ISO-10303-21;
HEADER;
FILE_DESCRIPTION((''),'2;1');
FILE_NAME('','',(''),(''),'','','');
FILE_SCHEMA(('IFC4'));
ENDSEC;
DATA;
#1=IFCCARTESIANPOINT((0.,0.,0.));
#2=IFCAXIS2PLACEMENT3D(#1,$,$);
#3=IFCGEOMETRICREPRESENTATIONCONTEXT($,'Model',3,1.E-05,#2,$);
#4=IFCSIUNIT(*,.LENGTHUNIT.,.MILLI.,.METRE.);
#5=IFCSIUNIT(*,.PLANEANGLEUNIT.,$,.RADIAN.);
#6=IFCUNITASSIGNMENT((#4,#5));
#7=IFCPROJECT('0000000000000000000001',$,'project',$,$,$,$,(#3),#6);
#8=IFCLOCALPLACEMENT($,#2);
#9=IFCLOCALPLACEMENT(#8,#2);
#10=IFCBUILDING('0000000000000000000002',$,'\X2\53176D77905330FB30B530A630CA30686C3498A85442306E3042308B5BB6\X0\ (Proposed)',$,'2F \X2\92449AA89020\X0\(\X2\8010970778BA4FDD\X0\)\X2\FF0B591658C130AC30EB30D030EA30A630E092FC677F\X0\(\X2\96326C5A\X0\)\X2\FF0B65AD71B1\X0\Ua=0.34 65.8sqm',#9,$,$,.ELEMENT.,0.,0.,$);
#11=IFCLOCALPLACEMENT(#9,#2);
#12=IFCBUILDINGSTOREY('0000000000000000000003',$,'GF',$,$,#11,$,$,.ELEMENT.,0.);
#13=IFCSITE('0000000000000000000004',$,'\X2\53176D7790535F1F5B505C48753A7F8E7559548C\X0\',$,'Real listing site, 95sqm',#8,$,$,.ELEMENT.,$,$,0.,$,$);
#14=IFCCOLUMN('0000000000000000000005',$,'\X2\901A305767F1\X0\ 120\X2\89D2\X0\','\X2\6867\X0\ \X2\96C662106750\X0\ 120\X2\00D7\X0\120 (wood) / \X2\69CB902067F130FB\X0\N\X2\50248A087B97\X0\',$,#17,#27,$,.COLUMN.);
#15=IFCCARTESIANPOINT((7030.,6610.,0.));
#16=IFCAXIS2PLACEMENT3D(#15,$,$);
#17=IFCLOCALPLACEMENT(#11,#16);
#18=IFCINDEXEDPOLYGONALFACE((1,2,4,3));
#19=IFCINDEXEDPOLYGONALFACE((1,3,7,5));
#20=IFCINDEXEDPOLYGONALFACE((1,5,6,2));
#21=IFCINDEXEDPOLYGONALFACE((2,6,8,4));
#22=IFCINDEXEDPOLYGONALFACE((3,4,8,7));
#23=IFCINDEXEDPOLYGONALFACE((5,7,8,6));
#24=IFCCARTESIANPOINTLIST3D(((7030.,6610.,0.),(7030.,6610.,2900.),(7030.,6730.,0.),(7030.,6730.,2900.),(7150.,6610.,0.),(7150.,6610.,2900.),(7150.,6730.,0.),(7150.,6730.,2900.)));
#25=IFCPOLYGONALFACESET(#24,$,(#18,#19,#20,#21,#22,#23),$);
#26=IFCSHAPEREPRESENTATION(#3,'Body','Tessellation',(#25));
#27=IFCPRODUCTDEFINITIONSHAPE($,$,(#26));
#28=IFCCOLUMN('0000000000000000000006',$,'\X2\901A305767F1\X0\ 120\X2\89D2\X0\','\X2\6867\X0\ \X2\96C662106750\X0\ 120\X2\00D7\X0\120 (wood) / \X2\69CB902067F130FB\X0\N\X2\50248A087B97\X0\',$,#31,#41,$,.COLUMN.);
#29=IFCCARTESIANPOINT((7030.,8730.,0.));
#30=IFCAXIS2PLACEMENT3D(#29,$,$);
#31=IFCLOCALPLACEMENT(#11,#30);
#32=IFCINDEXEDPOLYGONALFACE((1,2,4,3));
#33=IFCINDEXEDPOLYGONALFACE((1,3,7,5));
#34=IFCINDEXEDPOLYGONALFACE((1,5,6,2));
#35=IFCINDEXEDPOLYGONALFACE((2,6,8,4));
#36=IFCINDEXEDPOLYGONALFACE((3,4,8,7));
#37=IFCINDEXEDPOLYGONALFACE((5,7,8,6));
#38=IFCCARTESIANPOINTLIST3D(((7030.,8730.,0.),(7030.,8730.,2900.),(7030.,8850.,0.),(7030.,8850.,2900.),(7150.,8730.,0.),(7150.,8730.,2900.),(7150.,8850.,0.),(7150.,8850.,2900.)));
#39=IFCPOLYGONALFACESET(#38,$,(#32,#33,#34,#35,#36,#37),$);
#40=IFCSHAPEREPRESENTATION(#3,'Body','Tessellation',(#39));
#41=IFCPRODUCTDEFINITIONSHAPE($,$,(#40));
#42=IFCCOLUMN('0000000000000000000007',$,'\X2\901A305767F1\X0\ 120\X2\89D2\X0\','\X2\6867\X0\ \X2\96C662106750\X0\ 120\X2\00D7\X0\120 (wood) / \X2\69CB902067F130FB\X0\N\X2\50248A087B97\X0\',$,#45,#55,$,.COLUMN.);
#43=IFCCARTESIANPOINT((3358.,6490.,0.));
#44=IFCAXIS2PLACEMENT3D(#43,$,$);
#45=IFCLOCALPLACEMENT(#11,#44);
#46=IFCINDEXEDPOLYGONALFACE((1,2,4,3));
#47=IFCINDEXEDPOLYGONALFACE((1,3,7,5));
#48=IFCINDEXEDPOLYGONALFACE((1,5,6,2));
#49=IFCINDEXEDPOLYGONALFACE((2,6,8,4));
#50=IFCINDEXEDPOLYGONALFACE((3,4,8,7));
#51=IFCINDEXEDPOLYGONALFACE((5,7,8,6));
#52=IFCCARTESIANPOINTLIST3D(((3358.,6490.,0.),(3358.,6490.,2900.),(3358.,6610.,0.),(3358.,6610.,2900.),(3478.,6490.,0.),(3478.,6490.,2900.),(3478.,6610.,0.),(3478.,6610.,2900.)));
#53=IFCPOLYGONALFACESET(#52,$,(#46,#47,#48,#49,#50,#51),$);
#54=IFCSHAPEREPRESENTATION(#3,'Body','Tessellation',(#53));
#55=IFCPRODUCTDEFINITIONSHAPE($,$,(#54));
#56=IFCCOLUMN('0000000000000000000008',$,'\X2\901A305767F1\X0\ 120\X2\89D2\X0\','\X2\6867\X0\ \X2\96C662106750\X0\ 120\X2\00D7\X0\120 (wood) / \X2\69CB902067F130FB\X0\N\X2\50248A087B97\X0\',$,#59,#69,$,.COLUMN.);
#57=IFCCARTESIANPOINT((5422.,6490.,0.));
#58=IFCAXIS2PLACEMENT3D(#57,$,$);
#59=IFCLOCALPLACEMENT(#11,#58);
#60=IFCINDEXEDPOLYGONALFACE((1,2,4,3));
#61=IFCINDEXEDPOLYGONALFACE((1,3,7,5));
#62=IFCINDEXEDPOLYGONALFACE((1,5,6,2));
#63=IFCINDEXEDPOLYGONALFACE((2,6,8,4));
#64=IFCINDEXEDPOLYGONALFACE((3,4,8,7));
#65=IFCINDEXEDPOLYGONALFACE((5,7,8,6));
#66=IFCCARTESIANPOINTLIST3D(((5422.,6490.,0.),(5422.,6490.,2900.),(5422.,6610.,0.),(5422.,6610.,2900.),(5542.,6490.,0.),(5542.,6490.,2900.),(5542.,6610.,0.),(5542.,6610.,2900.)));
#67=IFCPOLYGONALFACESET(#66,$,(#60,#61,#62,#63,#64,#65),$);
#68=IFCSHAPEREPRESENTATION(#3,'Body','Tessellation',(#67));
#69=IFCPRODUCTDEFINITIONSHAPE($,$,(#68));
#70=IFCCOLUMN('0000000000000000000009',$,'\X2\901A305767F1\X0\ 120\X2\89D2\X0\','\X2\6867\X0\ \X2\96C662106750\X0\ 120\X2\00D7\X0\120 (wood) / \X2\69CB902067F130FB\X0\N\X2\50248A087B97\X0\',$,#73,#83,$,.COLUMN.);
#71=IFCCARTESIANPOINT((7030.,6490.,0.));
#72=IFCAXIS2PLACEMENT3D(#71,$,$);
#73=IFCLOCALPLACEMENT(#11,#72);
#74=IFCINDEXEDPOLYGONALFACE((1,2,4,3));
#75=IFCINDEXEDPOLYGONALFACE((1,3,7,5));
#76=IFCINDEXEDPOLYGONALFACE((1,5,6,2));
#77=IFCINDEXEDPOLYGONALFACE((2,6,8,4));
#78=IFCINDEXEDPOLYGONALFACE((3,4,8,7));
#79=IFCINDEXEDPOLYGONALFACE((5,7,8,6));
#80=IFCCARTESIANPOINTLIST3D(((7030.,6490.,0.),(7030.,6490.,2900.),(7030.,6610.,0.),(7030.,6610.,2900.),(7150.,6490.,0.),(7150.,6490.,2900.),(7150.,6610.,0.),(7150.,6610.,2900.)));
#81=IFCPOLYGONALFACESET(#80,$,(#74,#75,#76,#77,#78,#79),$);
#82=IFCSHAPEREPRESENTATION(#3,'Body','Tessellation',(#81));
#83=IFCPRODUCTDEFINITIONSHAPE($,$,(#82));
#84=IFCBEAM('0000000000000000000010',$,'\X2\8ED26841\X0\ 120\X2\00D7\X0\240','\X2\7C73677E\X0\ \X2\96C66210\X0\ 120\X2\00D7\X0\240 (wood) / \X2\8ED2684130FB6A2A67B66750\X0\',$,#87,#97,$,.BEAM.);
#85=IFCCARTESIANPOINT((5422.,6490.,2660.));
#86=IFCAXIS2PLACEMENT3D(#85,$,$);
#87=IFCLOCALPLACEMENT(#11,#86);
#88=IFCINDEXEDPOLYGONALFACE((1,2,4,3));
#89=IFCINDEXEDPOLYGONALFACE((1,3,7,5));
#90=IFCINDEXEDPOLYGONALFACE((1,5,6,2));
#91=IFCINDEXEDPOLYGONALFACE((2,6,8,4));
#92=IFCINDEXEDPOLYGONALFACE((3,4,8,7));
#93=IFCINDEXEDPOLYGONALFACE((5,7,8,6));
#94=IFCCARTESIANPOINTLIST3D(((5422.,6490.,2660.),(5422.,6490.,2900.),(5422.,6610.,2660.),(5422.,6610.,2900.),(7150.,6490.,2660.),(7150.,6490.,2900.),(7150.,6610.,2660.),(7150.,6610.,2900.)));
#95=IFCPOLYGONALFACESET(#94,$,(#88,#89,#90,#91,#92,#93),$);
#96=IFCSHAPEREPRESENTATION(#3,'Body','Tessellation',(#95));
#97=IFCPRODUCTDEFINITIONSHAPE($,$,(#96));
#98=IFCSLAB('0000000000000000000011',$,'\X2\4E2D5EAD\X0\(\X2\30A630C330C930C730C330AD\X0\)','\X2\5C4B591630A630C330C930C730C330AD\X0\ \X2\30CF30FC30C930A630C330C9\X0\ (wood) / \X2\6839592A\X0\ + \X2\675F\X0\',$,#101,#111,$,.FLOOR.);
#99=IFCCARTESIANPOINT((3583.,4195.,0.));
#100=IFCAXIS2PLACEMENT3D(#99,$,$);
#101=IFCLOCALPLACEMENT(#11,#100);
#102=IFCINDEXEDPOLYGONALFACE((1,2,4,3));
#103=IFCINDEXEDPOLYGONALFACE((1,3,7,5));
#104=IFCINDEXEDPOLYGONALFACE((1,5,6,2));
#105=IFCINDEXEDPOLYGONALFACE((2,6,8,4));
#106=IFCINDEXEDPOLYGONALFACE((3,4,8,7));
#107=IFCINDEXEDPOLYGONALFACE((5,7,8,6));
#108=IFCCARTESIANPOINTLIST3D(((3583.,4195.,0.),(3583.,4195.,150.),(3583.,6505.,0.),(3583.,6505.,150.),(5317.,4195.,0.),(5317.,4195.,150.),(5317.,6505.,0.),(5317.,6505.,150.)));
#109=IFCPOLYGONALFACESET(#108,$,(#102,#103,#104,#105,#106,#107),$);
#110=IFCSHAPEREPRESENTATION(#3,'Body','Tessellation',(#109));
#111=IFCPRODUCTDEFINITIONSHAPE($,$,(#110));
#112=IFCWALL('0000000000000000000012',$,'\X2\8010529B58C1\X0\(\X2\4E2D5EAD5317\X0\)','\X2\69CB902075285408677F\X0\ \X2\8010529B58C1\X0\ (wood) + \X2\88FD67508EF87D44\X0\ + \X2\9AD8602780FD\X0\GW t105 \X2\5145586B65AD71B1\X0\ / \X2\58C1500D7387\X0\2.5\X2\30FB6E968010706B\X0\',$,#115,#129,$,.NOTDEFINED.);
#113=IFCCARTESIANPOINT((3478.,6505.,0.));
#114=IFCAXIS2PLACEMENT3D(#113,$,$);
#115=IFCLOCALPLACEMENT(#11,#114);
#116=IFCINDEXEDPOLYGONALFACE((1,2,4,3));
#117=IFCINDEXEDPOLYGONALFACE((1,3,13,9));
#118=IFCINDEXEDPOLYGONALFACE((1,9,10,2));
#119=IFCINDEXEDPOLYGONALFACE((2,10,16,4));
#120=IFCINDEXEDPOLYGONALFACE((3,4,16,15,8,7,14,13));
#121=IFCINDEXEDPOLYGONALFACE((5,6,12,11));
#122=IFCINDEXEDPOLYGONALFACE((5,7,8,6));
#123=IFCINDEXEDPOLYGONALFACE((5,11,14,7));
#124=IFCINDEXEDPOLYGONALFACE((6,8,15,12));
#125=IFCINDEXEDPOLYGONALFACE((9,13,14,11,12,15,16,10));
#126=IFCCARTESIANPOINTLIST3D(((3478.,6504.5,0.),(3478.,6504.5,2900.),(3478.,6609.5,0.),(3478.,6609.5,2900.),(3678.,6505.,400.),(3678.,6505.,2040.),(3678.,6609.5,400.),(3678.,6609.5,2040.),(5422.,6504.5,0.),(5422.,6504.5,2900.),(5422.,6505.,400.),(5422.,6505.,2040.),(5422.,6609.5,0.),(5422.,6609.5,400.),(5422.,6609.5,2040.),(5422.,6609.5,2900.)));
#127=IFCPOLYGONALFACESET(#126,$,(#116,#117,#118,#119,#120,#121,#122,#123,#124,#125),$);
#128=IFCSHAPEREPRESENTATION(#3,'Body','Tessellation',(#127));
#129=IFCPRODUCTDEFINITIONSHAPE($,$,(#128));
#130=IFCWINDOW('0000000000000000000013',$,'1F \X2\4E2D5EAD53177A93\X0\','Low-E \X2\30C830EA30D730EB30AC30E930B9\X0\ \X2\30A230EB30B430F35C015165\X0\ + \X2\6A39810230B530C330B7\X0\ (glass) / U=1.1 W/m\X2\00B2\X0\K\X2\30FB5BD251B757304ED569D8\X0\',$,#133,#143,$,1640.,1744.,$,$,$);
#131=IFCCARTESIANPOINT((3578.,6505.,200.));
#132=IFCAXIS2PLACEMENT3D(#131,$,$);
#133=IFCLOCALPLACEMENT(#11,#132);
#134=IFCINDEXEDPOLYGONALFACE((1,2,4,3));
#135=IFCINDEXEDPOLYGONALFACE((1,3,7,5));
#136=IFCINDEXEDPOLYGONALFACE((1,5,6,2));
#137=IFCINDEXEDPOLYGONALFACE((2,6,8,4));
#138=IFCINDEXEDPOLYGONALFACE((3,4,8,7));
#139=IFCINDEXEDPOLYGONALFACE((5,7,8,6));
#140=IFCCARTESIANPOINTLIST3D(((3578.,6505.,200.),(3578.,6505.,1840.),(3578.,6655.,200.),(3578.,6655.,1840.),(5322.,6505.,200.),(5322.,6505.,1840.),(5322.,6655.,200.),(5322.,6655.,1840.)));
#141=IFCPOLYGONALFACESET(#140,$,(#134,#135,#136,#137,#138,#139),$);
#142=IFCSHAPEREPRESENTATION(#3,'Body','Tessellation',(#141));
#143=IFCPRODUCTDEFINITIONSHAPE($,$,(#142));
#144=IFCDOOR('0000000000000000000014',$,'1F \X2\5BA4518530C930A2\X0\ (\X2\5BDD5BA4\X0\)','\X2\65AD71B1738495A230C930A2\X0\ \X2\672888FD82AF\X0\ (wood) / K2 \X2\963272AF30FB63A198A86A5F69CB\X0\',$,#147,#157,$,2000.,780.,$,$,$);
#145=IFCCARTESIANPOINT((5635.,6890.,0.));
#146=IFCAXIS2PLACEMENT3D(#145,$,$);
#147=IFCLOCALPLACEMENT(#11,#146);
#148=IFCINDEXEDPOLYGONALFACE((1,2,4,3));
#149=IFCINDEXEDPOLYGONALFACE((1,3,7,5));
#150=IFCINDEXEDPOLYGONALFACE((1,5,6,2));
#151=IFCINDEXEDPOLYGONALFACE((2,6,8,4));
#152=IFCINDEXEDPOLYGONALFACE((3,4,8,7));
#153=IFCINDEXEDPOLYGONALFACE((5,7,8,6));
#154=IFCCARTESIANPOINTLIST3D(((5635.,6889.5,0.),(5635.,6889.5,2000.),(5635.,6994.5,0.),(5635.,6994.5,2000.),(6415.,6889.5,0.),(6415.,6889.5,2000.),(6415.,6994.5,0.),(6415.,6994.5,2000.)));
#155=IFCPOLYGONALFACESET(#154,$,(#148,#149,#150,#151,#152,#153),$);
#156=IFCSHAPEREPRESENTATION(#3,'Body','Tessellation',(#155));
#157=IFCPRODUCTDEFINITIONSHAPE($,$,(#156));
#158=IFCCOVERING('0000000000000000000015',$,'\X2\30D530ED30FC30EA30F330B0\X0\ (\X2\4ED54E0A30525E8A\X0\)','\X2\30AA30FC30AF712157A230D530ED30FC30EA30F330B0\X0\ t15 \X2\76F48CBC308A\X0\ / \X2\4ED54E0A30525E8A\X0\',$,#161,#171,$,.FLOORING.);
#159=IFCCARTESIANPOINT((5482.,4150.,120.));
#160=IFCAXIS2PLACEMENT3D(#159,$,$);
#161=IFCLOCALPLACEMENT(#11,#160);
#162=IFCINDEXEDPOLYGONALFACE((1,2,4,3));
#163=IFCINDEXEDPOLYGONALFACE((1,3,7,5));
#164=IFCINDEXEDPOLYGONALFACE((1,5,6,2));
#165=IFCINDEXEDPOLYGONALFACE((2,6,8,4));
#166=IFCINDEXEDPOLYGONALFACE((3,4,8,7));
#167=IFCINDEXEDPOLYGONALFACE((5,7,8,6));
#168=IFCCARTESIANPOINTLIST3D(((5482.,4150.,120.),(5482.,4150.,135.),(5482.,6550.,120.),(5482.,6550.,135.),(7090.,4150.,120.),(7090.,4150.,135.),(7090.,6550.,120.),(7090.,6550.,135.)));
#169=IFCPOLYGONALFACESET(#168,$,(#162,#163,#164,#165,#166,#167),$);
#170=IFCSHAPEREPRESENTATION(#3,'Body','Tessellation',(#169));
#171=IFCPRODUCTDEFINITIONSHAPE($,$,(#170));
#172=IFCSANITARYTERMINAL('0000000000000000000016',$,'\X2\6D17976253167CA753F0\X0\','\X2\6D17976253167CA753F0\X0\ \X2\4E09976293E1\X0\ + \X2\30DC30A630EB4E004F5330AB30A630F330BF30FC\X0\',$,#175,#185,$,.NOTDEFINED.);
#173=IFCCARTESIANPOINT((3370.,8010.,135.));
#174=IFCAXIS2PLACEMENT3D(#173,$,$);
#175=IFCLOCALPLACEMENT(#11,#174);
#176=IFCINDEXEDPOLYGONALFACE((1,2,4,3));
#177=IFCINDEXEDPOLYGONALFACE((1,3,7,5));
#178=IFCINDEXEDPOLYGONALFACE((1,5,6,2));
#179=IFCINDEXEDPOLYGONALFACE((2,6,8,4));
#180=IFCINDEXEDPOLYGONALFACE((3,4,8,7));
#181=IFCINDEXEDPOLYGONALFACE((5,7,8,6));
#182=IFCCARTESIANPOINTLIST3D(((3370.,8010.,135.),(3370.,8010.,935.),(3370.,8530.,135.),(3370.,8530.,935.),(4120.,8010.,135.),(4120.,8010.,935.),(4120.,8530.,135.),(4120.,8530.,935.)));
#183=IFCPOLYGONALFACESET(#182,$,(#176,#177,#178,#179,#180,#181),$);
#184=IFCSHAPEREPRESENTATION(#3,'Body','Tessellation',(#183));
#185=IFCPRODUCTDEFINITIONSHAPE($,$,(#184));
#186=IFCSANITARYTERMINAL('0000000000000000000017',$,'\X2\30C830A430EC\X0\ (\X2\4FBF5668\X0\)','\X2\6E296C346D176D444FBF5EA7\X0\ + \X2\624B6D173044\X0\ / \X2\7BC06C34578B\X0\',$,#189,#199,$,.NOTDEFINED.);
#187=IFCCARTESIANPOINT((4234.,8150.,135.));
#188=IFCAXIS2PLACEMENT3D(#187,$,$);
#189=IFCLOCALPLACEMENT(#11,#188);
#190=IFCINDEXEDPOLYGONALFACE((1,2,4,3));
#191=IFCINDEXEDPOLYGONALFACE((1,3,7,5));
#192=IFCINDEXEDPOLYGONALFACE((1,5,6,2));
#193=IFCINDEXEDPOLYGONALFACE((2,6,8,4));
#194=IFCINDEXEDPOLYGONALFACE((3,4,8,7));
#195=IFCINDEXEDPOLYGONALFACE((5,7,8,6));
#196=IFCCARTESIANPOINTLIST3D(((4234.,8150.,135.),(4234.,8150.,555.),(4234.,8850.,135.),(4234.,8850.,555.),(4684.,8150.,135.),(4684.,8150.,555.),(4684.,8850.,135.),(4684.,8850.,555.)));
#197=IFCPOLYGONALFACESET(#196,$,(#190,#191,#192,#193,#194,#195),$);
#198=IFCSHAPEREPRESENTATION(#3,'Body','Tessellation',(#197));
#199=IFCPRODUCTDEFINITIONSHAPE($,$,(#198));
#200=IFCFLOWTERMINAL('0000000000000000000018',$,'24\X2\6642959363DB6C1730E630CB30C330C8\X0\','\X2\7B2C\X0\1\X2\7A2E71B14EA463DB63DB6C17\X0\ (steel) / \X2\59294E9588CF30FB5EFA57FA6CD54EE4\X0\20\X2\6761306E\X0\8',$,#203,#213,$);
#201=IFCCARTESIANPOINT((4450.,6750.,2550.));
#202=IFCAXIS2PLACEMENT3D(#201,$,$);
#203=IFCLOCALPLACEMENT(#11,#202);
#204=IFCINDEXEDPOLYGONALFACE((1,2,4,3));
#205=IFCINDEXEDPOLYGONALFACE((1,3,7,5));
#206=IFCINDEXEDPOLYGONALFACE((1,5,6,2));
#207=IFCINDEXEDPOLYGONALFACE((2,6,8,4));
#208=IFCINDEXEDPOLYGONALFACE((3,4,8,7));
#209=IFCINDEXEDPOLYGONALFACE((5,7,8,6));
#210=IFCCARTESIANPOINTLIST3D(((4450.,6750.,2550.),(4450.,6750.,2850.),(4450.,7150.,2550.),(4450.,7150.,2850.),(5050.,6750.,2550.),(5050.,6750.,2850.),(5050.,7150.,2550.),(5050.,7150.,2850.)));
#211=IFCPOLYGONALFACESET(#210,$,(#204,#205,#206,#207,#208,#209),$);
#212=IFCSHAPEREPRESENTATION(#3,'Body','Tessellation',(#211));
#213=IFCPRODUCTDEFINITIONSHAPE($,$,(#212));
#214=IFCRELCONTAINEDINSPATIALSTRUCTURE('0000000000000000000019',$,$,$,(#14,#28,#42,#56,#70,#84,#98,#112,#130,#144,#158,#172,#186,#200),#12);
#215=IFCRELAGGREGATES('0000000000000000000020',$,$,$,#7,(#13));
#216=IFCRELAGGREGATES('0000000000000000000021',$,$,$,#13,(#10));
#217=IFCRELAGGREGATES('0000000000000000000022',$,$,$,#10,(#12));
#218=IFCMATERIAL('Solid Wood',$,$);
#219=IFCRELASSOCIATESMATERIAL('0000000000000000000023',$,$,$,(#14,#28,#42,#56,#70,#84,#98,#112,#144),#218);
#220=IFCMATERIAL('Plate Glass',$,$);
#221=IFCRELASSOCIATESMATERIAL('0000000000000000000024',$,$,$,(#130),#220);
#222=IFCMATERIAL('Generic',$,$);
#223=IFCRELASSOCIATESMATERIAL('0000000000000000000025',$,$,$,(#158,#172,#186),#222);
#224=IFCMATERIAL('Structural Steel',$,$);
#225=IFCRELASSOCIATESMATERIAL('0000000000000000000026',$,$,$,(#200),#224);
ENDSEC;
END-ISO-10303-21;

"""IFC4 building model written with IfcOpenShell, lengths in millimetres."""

from ifc_helpers import new_model, si_unit, frame, frame_2d, origin, place, context, project, spatial, rectangle, extrude, material, element, fill, save


model = new_model("IFC4")

# Units and contexts
model_context = context("Model", 3, precision=1e-05, world=origin())
ifc_project = project(units=[si_unit("LENGTHUNIT", "METRE", prefix="MILLI"), si_unit("PLANEANGLEUNIT", "RADIAN")], contexts=[model_context])

# Site, building, storey
site_placement = place(None, origin())
site = spatial("IfcSite", under=ifc_project, at=site_placement, Name="北海道弟子屈町美留和", ObjectType="Real listing site, 95sqm", CompositionType="ELEMENT", RefElevation=0.0)
building_placement = place(site_placement, origin())
building = spatial("IfcBuilding", under=site, at=building_placement, Name="北海道・サウナと水風呂のある家 (Proposed)", ObjectType="2F 鉄骨造(耐震確保)＋外壁ガルバリウム鋼板(防汚)＋断熱Ua=0.34 65.8sqm", CompositionType="ELEMENT", ElevationOfRefHeight=0.0, ElevationOfTerrain=0.0)
storey_placement = place(building_placement, origin())
storey = spatial("IfcBuildingStorey", under=building, at=storey_placement, Name="GF", CompositionType="ELEMENT", Elevation=0.0)

# Columns
ifc_material_1 = material(Name="Solid Wood")
column_1_placement = place(storey_placement, frame((7030.0, 6610.0, 0.0)))
element("IfcColumn", 1, at=column_1_placement, inside=storey, material=ifc_material_1, Name="通し柱 120角", Description="桧 集成材 120×120 (wood) / 構造柱・N値計算", PredefinedType="COLUMN", context=model_context, shape_type="SweptSolid", body=[
    extrude(rectangle(XDim=120.0, YDim=120.0, at=frame_2d((60.0, 60.0))), frame((7030.0, 6610.0, 0.0)), (0.0, 0.0, 1.0), 2900.0),
])
column_2_placement = place(storey_placement, frame((7030.0, 8730.0, 0.0)))
element("IfcColumn", 2, at=column_2_placement, inside=storey, material=ifc_material_1, Name="通し柱 120角", Description="桧 集成材 120×120 (wood) / 構造柱・N値計算", PredefinedType="COLUMN", context=model_context, shape_type="SweptSolid", body=[
    extrude(rectangle(XDim=120.0, YDim=120.0, at=frame_2d((60.0, 60.0))), frame((7030.0, 8730.0, 0.0)), (0.0, 0.0, 1.0), 2900.0),
])
column_3_placement = place(storey_placement, frame((3358.0, 6490.0, 0.0)))
element("IfcColumn", 3, at=column_3_placement, inside=storey, material=ifc_material_1, Name="通し柱 120角", Description="桧 集成材 120×120 (wood) / 構造柱・N値計算", PredefinedType="COLUMN", context=model_context, shape_type="SweptSolid", body=[
    extrude(rectangle(XDim=120.0, YDim=120.0, at=frame_2d((60.0, 60.0))), frame((3358.0, 6490.0, 0.0)), (0.0, 0.0, 1.0), 2900.0),
])
column_4_placement = place(storey_placement, frame((5422.0, 6490.0, 0.0)))
element("IfcColumn", 4, at=column_4_placement, inside=storey, material=ifc_material_1, Name="通し柱 120角", Description="桧 集成材 120×120 (wood) / 構造柱・N値計算", PredefinedType="COLUMN", context=model_context, shape_type="SweptSolid", body=[
    extrude(rectangle(XDim=120.0, YDim=120.0, at=frame_2d((60.0, 60.0))), frame((5422.0, 6490.0, 0.0)), (0.0, 0.0, 1.0), 2900.0),
])
column_5_placement = place(storey_placement, frame((7030.0, 6490.0, 0.0)))
element("IfcColumn", 5, at=column_5_placement, inside=storey, material=ifc_material_1, Name="通し柱 120角", Description="桧 集成材 120×120 (wood) / 構造柱・N値計算", PredefinedType="COLUMN", context=model_context, shape_type="SweptSolid", body=[
    extrude(rectangle(XDim=120.0, YDim=120.0, at=frame_2d((60.0, 60.0))), frame((7030.0, 6490.0, 0.0)), (0.0, 0.0, 1.0), 2900.0),
])

# Beam
beam_1_placement = place(storey_placement, frame((5422.0, 6490.0, 2660.0)))
element("IfcBeam", 6, at=beam_1_placement, inside=storey, material=ifc_material_1, Name="軒桁 120×240", Description="米松 集成 120×240 (wood) / 軒桁・横架材", PredefinedType="BEAM", context=model_context, shape_type="SweptSolid", body=[
    extrude(rectangle(XDim=1728.0, YDim=120.0, at=frame_2d((864.0, 60.0))), frame((5422.0, 6490.0, 2660.0)), (0.0, 0.0, 1.0), 240.0),
])

# Slab
slab_placement = place(storey_placement, frame((3583.0, 4195.0, 0.0)))
element("IfcSlab", 7, at=slab_placement, inside=storey, material=ifc_material_1, Name="中庭(ウッドデッキ)", Description="屋外ウッドデッキ ハードウッド (wood) / 根太 + 束", PredefinedType="FLOOR", context=model_context, shape_type="SweptSolid", body=[
    extrude(rectangle(XDim=1734.0, YDim=2310.0, at=frame_2d((867.0, 1155.0))), frame((3583.0, 4195.0, 0.0)), (0.0, 0.0, 1.0), 150.0),
])

# Wall, opening, window
wall_1_placement = place(storey_placement, frame((3478.0, 6505.0, 0.0)))
wall_1 = element("IfcWall", 8, at=wall_1_placement, inside=storey, material=ifc_material_1, Name="耐力壁(中庭北)", Description="構造用合板 耐力壁 (wood) + 製材軸組 + 高性能GW t105 充填断熱 / 壁倍率2.5・準耐火", PredefinedType="NOTDEFINED", context=model_context, shape_type="SweptSolid", body=[
    extrude(rectangle(XDim=1944.0, YDim=105.0, at=frame_2d((972.0, 52.0))), frame((3478.0, 6505.0, 0.0)), (0.0, 0.0, 1.0), 2900.0),
])
opening_placement = place(storey_placement, frame((3578.0, 6505.0, 200.0)))
opening = element("IfcOpeningElement", 9, at=opening_placement, cuts=wall_1, PredefinedType="NOTDEFINED", context=model_context, shape_type="SweptSolid", body=[
    extrude(rectangle(XDim=1744.0, YDim=150.0, at=frame_2d((872.0, 75.0))), frame((3578.0, 6505.0, 200.0)), (0.0, 0.0, 1.0), 1640.0),
])
ifc_material_2 = material(Name="Plate Glass")
window_placement = place(storey_placement, frame((3578.0, 6505.0, 200.0)))
window = element("IfcWindow", 10, at=window_placement, inside=storey, material=ifc_material_2, Name="1F 中庭北窓", Description="Low-E トリプルガラス アルゴン封入 + 樹脂サッシ (glass) / U=1.1 W/m²K・寒冷地仕様", OverallHeight=1640.0, OverallWidth=1744.0, context=model_context, shape_type="SweptSolid", body=[
    extrude(rectangle(XDim=1744.0, YDim=150.0, at=frame_2d((872.0, 75.0))), frame((3578.0, 6505.0, 200.0)), (0.0, 0.0, 1.0), 1640.0),
])
fill(opening, window)

# Door
door_placement = place(storey_placement, frame((5635.0, 6890.0, 0.0)))
element("IfcDoor", 11, at=door_placement, inside=storey, material=ifc_material_1, Name="1F 室内ドア (寝室)", Description="断熱玄関ドア 木製芯 (wood) / K2 防犯・採風機構", OverallHeight=2000.0, OverallWidth=780.0, context=model_context, shape_type="SweptSolid", body=[
    extrude(rectangle(XDim=780.0, YDim=105.0, at=frame_2d((390.0, 52.0))), frame((5635.0, 6890.0, 0.0)), (0.0, 0.0, 1.0), 2000.0),
])

# Covering
ifc_material_3 = material(Name="Generic")
covering_placement = place(storey_placement, frame((5482.0, 4150.0, 120.0)))
element("IfcCovering", 12, at=covering_placement, inside=storey, material=ifc_material_3, Name="フローリング (仕上げ床)", Description="オーク無垢フローリング t15 直貼り / 仕上げ床", PredefinedType="FLOORING", context=model_context, shape_type="SweptSolid", body=[
    extrude(rectangle(XDim=1608.0, YDim=2400.0, at=frame_2d((804.0, 1200.0))), frame((5482.0, 4150.0, 120.0)), (0.0, 0.0, 1.0), 15.0),
])

# Sanitary terminals
sanitary_terminal_1_placement = place(storey_placement, frame((3370.0, 8010.0, 135.0)))
element("IfcSanitaryTerminal", 13, at=sanitary_terminal_1_placement, inside=storey, material=ifc_material_3, Name="洗面化粧台", Description="洗面化粧台 三面鏡 + ボウル一体カウンター", PredefinedType="NOTDEFINED", context=model_context, shape_type="SweptSolid", body=[
    extrude(rectangle(XDim=750.0, YDim=520.0, at=frame_2d((375.0, 260.0))), frame((3370.0, 8010.0, 135.0)), (0.0, 0.0, 1.0), 800.0),
])
sanitary_terminal_2_placement = place(storey_placement, frame((4234.0, 8150.0, 135.0)))
element("IfcSanitaryTerminal", 14, at=sanitary_terminal_2_placement, inside=storey, material=ifc_material_3, Name="トイレ (便器)", Description="温水洗浄便座 + 手洗い / 節水型", PredefinedType="NOTDEFINED", context=model_context, shape_type="SweptSolid", body=[
    extrude(rectangle(XDim=450.0, YDim=700.0, at=frame_2d((225.0, 350.0))), frame((4234.0, 8150.0, 135.0)), (0.0, 0.0, 1.0), 420.0),
])

# Flow terminal
ifc_material_4 = material(Name="Structural Steel")
flow_terminal_placement = place(storey_placement, frame((4450.0, 6750.0, 2550.0)))
element("IfcFlowTerminal", 15, at=flow_terminal_placement, inside=storey, material=ifc_material_4, Name="24時間換気ユニット", Description="第1種熱交換換気 (steel) / 天井裏・建基法令20条の8", context=model_context, shape_type="SweptSolid", body=[
    extrude(rectangle(XDim=600.0, YDim=400.0, at=frame_2d((300.0, 200.0))), frame((4450.0, 6750.0, 2550.0)), (0.0, 0.0, 1.0), 300.0),
])

save(model, "model.ifc")
